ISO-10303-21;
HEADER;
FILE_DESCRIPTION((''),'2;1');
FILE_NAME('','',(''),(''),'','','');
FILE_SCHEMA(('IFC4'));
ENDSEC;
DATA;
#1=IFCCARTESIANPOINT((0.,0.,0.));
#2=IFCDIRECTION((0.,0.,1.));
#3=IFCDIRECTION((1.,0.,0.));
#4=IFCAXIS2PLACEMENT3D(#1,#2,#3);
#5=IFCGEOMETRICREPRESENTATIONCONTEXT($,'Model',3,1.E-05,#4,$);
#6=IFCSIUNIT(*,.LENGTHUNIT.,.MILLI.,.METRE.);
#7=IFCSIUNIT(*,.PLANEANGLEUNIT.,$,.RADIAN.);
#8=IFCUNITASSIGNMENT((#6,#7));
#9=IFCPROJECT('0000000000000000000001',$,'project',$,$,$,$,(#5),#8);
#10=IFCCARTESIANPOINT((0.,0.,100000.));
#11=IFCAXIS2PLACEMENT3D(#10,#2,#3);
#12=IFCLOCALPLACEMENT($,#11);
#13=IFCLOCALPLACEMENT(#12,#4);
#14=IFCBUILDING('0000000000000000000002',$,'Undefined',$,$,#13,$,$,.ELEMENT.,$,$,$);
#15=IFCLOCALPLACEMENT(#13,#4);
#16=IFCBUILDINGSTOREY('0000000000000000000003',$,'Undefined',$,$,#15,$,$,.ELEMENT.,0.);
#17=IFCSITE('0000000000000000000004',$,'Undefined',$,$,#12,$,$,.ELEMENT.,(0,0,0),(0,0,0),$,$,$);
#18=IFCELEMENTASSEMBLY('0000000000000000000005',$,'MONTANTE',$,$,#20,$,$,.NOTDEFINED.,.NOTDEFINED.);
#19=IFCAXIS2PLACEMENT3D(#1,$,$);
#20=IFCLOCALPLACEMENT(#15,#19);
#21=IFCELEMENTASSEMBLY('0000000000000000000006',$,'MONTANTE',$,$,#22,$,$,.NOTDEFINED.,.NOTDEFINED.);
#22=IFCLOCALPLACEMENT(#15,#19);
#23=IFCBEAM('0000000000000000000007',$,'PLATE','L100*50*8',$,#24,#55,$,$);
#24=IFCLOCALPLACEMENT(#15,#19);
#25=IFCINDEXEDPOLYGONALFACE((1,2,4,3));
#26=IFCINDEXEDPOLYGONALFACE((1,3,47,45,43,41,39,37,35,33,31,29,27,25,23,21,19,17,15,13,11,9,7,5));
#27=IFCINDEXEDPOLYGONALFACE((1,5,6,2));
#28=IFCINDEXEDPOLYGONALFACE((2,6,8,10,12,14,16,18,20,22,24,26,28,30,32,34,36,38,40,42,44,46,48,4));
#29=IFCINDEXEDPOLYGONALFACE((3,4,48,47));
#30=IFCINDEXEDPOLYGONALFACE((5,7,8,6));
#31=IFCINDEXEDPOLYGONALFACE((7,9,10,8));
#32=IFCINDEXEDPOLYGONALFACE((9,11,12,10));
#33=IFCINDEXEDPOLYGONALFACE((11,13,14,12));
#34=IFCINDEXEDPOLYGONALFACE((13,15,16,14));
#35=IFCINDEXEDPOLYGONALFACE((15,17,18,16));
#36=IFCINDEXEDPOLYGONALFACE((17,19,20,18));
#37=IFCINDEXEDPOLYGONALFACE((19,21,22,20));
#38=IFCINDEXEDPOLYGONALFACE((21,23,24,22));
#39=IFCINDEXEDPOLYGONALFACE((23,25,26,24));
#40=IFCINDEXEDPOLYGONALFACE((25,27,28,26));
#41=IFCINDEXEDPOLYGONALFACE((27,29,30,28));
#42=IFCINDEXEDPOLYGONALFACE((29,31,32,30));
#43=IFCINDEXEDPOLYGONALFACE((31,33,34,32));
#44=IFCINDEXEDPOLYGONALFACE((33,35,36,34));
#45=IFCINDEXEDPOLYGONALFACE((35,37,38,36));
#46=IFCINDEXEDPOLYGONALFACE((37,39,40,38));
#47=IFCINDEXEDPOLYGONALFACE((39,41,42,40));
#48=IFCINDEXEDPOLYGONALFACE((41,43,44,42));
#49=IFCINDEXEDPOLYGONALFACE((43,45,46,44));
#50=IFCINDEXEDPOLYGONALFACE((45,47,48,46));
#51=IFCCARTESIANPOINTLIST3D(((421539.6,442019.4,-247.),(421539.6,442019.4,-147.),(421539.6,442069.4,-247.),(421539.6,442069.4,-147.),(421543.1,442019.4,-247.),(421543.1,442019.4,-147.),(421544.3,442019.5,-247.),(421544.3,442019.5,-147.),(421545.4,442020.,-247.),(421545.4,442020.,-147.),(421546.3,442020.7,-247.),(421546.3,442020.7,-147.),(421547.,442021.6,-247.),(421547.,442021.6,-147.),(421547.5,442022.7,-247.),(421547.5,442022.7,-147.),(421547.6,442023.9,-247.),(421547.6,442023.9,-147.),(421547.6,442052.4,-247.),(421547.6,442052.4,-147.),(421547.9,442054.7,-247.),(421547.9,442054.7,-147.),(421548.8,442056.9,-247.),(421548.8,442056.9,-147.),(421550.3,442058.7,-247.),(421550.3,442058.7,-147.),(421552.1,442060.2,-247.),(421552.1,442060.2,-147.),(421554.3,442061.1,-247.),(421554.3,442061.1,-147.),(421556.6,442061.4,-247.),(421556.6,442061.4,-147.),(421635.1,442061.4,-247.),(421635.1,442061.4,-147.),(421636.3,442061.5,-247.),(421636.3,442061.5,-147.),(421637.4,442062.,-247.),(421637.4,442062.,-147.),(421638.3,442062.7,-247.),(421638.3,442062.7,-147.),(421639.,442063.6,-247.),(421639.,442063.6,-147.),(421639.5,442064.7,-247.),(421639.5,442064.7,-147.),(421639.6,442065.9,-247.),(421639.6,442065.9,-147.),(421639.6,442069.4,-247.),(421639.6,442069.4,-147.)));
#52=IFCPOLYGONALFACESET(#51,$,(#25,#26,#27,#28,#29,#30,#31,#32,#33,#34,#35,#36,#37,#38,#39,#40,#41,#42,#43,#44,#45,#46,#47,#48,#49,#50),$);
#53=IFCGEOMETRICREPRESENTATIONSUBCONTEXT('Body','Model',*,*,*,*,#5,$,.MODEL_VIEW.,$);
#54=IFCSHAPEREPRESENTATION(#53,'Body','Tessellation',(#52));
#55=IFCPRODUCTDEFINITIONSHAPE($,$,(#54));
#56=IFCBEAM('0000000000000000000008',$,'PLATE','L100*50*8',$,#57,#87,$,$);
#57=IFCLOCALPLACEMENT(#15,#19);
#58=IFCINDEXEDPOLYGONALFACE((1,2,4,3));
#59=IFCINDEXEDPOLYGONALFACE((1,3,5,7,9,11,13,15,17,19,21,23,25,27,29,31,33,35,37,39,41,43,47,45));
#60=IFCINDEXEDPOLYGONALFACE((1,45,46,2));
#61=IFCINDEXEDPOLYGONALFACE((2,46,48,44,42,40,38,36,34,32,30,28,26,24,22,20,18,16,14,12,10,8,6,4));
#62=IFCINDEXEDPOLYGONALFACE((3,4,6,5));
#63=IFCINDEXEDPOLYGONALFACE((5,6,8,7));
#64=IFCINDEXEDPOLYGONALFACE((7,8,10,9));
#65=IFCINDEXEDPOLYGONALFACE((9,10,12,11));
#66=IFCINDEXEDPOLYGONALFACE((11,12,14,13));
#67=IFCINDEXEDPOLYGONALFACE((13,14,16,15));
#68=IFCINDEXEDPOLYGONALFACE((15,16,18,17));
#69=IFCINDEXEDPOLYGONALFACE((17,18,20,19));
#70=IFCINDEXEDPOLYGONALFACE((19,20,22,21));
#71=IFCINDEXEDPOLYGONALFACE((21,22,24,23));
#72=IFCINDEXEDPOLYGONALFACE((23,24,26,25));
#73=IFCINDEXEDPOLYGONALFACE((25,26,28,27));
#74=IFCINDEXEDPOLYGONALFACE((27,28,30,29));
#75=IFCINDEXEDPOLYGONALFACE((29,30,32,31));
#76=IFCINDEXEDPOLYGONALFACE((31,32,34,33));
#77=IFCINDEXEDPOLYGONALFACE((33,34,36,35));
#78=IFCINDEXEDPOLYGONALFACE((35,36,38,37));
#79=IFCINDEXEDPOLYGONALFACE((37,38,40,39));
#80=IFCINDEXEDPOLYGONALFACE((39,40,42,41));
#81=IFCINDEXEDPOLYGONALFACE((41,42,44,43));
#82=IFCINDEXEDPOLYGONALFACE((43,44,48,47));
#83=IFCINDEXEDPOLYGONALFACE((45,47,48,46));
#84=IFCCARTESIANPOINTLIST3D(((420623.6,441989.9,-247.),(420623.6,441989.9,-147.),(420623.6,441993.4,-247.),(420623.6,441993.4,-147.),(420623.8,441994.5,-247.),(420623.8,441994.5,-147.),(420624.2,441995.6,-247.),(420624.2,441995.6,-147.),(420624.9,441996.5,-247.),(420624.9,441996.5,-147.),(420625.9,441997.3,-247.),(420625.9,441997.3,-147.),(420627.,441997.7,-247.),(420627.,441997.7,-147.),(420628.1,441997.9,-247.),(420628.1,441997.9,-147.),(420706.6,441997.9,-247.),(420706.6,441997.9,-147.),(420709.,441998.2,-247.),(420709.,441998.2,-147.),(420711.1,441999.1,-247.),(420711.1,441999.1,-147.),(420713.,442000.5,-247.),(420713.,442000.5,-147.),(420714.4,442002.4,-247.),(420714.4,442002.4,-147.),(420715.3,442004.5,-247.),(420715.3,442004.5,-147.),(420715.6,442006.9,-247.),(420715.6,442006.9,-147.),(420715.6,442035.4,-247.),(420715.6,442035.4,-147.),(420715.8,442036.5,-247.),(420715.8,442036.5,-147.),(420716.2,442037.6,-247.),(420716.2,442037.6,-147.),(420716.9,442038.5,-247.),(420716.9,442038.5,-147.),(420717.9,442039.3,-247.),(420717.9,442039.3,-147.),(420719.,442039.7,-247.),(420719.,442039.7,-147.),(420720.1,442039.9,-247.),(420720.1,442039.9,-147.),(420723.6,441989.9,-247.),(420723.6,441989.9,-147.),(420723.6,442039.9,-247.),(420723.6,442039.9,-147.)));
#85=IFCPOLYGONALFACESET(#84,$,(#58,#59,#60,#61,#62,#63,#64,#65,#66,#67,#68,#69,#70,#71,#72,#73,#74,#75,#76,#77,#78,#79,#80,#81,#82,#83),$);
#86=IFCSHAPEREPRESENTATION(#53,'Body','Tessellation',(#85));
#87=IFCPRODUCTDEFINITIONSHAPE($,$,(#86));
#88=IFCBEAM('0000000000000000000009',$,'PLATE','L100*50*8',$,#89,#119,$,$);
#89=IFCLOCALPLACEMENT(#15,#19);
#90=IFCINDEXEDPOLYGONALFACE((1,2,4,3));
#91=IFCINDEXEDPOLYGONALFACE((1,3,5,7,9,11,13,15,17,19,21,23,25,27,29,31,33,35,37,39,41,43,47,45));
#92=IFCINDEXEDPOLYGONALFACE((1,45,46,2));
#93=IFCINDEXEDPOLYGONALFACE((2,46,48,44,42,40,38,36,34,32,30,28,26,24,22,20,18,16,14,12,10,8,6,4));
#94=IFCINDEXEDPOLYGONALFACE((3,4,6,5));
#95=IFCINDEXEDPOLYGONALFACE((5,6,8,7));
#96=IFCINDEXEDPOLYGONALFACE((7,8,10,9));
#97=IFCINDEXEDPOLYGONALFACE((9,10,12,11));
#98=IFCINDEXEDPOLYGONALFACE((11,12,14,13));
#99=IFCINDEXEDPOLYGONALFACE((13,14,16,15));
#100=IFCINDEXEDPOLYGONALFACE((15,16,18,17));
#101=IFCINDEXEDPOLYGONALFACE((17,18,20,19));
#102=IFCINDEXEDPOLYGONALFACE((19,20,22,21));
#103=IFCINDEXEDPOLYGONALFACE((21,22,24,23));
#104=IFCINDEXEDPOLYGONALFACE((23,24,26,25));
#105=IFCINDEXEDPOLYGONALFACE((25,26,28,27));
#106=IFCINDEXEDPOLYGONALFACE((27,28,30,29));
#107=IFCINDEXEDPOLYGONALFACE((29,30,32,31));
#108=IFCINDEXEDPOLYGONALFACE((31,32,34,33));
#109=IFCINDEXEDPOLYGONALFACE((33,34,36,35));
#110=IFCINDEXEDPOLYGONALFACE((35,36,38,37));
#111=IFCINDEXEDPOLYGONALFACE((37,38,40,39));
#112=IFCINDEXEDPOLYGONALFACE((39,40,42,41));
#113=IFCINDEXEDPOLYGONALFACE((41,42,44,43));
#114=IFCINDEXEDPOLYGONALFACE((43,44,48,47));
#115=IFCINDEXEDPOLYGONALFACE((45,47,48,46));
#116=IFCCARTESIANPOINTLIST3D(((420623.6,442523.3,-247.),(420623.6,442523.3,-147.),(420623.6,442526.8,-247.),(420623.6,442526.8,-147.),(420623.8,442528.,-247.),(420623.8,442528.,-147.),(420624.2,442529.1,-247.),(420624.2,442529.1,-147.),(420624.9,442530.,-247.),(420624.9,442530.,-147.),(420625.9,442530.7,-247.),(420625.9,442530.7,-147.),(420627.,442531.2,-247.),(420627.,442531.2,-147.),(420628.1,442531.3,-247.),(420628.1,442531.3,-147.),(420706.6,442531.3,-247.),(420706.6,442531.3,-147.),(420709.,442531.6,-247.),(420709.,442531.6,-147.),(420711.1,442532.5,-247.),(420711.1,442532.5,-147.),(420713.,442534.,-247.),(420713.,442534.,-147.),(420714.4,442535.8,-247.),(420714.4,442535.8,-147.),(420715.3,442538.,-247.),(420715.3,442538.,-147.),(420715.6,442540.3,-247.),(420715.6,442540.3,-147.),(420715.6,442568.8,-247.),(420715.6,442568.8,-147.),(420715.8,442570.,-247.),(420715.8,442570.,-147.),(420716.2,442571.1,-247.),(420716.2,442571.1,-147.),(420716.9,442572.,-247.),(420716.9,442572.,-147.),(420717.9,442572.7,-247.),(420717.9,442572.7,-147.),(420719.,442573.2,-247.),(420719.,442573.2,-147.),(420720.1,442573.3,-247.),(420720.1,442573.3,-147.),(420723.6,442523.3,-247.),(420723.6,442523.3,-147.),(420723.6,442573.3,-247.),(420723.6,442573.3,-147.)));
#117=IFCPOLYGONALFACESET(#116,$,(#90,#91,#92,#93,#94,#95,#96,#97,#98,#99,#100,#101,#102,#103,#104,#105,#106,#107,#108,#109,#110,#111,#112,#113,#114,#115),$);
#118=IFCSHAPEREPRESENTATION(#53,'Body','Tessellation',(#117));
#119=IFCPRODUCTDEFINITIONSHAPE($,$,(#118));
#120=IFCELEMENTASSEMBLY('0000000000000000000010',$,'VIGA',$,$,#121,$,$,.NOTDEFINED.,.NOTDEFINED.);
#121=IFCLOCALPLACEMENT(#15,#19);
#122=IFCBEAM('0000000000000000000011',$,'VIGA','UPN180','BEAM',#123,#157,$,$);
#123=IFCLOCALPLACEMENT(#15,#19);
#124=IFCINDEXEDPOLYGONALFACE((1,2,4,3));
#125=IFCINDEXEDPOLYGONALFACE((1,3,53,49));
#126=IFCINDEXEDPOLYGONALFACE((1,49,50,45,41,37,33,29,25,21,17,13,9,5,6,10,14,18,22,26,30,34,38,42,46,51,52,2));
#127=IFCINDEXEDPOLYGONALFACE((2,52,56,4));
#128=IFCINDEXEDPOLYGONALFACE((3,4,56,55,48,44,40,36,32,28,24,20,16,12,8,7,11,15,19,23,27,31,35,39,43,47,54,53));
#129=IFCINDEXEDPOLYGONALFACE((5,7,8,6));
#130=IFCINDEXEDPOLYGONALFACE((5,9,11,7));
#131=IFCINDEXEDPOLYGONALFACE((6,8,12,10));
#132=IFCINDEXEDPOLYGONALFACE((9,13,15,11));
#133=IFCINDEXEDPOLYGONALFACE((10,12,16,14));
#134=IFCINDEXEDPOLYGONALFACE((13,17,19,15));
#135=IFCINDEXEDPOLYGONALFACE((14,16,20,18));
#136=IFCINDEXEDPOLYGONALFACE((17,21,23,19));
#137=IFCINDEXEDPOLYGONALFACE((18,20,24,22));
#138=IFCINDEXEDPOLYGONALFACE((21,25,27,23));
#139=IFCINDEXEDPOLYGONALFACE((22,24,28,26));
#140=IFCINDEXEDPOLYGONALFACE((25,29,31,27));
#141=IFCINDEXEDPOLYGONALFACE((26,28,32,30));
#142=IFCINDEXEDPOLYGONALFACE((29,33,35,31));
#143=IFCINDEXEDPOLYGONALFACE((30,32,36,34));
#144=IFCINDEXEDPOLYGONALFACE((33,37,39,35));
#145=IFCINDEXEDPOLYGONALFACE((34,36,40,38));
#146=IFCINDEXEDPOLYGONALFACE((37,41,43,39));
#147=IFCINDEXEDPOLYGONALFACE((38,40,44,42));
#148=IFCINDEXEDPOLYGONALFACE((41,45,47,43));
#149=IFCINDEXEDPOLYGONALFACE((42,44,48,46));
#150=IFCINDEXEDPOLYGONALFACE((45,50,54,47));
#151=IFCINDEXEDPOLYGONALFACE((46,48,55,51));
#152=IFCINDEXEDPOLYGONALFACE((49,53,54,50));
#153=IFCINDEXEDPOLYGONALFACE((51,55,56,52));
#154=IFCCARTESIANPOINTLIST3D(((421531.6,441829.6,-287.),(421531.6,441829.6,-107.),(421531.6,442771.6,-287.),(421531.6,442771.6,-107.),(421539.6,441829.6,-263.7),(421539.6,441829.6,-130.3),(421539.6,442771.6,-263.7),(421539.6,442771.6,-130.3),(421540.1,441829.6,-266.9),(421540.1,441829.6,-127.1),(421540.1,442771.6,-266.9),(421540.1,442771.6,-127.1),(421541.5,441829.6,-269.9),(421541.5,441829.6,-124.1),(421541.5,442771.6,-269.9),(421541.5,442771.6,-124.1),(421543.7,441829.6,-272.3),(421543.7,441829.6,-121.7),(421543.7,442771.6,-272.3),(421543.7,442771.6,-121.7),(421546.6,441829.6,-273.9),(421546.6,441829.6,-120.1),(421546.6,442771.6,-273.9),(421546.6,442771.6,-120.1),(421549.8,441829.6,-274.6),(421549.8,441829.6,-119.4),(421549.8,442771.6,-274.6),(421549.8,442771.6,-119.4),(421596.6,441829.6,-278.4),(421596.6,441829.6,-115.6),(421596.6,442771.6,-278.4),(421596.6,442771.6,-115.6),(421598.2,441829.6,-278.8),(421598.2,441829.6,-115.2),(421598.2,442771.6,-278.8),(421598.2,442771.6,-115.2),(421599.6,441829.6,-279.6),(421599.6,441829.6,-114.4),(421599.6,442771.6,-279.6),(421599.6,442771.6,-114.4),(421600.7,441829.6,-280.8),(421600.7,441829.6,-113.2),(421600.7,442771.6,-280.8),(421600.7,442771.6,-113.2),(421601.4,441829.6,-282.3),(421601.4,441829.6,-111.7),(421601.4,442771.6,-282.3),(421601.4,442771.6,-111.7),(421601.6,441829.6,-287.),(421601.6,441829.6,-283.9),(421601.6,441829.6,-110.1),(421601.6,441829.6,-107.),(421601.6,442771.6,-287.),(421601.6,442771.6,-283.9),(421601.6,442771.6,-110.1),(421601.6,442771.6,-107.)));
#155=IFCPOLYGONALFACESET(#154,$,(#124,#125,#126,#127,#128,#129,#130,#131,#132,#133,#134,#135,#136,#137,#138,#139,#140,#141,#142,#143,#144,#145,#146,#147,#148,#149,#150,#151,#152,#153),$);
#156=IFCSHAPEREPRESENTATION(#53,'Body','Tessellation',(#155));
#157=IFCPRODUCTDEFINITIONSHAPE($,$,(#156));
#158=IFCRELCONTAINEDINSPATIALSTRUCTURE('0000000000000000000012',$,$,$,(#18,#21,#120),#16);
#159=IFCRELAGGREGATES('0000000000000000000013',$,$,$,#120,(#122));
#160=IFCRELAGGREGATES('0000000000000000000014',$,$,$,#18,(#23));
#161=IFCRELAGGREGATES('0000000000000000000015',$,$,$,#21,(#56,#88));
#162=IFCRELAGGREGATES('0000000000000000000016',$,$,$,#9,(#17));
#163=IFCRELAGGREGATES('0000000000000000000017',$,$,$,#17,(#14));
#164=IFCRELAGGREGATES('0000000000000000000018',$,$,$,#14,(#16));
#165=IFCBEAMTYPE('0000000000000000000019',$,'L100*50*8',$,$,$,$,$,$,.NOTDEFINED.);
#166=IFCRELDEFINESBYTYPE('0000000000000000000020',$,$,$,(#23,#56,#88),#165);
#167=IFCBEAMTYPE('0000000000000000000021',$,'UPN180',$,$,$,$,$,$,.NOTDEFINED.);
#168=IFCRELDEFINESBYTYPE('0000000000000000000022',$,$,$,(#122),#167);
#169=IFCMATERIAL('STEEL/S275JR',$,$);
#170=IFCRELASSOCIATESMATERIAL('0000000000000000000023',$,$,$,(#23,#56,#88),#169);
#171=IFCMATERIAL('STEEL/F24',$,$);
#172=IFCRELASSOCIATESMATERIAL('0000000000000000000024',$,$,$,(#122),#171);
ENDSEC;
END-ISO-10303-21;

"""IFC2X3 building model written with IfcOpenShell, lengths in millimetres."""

from ifc_helpers import new_model, si_unit, frame, origin_with_axes, origin_2d_with_axis, place, context, subcontext, project, spatial, l_section, u_section, extrude, material, type_object, element, aggregate, save


model = new_model("IFC2X3")

# Units and contexts
model_context = context("Model", 3, precision=1e-05, world=origin_with_axes())
body_context = subcontext(model_context, "Body", "Model", "MODEL_VIEW")
ifc_project = project(units=[si_unit("LENGTHUNIT", "METRE", prefix="MILLI"), si_unit("PLANEANGLEUNIT", "RADIAN")], contexts=[model_context])

# Site, building, storey
site_placement = place(None, frame((0.0, 0.0, 100000.0), z_axis=(0.0, 0.0, 1.0), x_axis=(1.0, 0.0, 0.0)))
site = spatial("IfcSite", under=ifc_project, at=site_placement, Name="Undefined", CompositionType="ELEMENT", RefLatitude=(0, 0, 0), RefLongitude=(0, 0, 0))
building_placement = place(site_placement, origin_with_axes())
building = spatial("IfcBuilding", under=site, at=building_placement, Name="Undefined", CompositionType="ELEMENT")
storey_placement = place(building_placement, origin_with_axes())
storey = spatial("IfcBuildingStorey", under=building, at=storey_placement, Name="Undefined", CompositionType="ELEMENT", Elevation=0.0)

# Element assembly
assembly_1_placement = place(storey_placement, origin_with_axes())
assembly_1 = element("IfcElementAssembly", 1, at=assembly_1_placement, inside=storey, Name="MONTANTE", AssemblyPlace="NOTDEFINED", PredefinedType="NOTDEFINED")
ifc_material_1 = material(Name="STEEL/F24")

# Element assembly
assembly_2_placement = place(storey_placement, origin_with_axes())
assembly_2 = element("IfcElementAssembly", 2, at=assembly_2_placement, inside=storey, Name="MONTANTE", AssemblyPlace="NOTDEFINED", PredefinedType="NOTDEFINED")

# Beams
ifc_material_2 = material(Name="STEEL/S275JR")
beam_type_1 = type_object("IfcBeamType", Name="L100*50*8", PredefinedType="NOTDEFINED")
beam_1_placement = place(assembly_1_placement, frame((421589.6, 442044.4, -147.0), z_axis=(1.0, 0.0, 0.0), x_axis=(0.0, 0.0, -1.0)))
beam_1 = element("IfcBeam", 3, at=beam_1_placement, type_object=beam_type_1, material=ifc_material_2, Name="PLATE", Description="L100*50*8", context=body_context, shape_type="SweptSolid", body=[
    extrude(l_section(Depth=100.0, Width=50.0, Thickness=8.0, FilletRadius=9.0, EdgeRadius=4.5, at=origin_2d_with_axis()), frame((100.0, 0.0, 0.0), z_axis=(-1.0, 0.0, 0.0), x_axis=(0.0, -1.0, 0.0)), (0.0, 0.0, 1.0), 100.0),
])
beam_2_placement = place(assembly_2_placement, frame((420673.6, 442014.9, -147.0), z_axis=(-1.0, 0.0, 0.0), x_axis=(0.0, 0.0, -1.0)))
beam_2 = element("IfcBeam", 4, at=beam_2_placement, type_object=beam_type_1, material=ifc_material_2, Name="PLATE", Description="L100*50*8", context=body_context, shape_type="SweptSolid", body=[
    extrude(l_section(Depth=100.0, Width=50.0, Thickness=8.0, FilletRadius=9.0, EdgeRadius=4.5, at=origin_2d_with_axis()), frame((100.0, 0.0, 0.0), z_axis=(-1.0, 0.0, 0.0), x_axis=(0.0, -1.0, 0.0)), (0.0, 0.0, 1.0), 100.0),
])
beam_3_placement = place(assembly_2_placement, frame((420673.6, 442548.3, -147.0), z_axis=(-1.0, 0.0, 0.0), x_axis=(0.0, 0.0, -1.0)))
beam_3 = element("IfcBeam", 5, at=beam_3_placement, type_object=beam_type_1, material=ifc_material_2, Name="PLATE", Description="L100*50*8", context=body_context, shape_type="SweptSolid", body=[
    extrude(l_section(Depth=100.0, Width=50.0, Thickness=8.0, FilletRadius=9.0, EdgeRadius=4.5, at=origin_2d_with_axis()), frame((100.0, 0.0, 0.0), z_axis=(-1.0, 0.0, 0.0), x_axis=(0.0, -1.0, 0.0)), (0.0, 0.0, 1.0), 100.0),
])

# Element assembly, beam
assembly_3_placement = place(storey_placement, origin_with_axes())
assembly_3 = element("IfcElementAssembly", 6, at=assembly_3_placement, inside=storey, Name="VIGA", AssemblyPlace="NOTDEFINED", PredefinedType="NOTDEFINED")
beam_type_2 = type_object("IfcBeamType", Name="UPN180", PredefinedType="NOTDEFINED")
beam_4_placement = place(assembly_3_placement, frame((421566.6, 442771.6, -197.0), z_axis=(0.0, 0.0, -1.0), x_axis=(0.0, -1.0, 0.0)))
beam_4 = element("IfcBeam", 7, at=beam_4_placement, type_object=beam_type_2, material=ifc_material_1, Name="VIGA", Description="UPN180", ObjectType="BEAM", context=body_context, shape_type="SweptSolid", body=[
    extrude(u_section(Depth=180.0, FlangeWidth=70.0, WebThickness=8.0, FlangeThickness=11.0, FilletRadius=11.0, EdgeRadius=5.5, FlangeSlope=0.07983, at=origin_2d_with_axis()), frame((941.9, 0.0, 0.0), z_axis=(-1.0, 0.0, 0.0), x_axis=(0.0, -1.0, 0.0)), (0.0, 0.0, 1.0), 942.0),
])
aggregate(assembly_3, [beam_4])

aggregate(assembly_1, [beam_1])
aggregate(assembly_2, [beam_2, beam_3])

save(model, "model.ifc")
